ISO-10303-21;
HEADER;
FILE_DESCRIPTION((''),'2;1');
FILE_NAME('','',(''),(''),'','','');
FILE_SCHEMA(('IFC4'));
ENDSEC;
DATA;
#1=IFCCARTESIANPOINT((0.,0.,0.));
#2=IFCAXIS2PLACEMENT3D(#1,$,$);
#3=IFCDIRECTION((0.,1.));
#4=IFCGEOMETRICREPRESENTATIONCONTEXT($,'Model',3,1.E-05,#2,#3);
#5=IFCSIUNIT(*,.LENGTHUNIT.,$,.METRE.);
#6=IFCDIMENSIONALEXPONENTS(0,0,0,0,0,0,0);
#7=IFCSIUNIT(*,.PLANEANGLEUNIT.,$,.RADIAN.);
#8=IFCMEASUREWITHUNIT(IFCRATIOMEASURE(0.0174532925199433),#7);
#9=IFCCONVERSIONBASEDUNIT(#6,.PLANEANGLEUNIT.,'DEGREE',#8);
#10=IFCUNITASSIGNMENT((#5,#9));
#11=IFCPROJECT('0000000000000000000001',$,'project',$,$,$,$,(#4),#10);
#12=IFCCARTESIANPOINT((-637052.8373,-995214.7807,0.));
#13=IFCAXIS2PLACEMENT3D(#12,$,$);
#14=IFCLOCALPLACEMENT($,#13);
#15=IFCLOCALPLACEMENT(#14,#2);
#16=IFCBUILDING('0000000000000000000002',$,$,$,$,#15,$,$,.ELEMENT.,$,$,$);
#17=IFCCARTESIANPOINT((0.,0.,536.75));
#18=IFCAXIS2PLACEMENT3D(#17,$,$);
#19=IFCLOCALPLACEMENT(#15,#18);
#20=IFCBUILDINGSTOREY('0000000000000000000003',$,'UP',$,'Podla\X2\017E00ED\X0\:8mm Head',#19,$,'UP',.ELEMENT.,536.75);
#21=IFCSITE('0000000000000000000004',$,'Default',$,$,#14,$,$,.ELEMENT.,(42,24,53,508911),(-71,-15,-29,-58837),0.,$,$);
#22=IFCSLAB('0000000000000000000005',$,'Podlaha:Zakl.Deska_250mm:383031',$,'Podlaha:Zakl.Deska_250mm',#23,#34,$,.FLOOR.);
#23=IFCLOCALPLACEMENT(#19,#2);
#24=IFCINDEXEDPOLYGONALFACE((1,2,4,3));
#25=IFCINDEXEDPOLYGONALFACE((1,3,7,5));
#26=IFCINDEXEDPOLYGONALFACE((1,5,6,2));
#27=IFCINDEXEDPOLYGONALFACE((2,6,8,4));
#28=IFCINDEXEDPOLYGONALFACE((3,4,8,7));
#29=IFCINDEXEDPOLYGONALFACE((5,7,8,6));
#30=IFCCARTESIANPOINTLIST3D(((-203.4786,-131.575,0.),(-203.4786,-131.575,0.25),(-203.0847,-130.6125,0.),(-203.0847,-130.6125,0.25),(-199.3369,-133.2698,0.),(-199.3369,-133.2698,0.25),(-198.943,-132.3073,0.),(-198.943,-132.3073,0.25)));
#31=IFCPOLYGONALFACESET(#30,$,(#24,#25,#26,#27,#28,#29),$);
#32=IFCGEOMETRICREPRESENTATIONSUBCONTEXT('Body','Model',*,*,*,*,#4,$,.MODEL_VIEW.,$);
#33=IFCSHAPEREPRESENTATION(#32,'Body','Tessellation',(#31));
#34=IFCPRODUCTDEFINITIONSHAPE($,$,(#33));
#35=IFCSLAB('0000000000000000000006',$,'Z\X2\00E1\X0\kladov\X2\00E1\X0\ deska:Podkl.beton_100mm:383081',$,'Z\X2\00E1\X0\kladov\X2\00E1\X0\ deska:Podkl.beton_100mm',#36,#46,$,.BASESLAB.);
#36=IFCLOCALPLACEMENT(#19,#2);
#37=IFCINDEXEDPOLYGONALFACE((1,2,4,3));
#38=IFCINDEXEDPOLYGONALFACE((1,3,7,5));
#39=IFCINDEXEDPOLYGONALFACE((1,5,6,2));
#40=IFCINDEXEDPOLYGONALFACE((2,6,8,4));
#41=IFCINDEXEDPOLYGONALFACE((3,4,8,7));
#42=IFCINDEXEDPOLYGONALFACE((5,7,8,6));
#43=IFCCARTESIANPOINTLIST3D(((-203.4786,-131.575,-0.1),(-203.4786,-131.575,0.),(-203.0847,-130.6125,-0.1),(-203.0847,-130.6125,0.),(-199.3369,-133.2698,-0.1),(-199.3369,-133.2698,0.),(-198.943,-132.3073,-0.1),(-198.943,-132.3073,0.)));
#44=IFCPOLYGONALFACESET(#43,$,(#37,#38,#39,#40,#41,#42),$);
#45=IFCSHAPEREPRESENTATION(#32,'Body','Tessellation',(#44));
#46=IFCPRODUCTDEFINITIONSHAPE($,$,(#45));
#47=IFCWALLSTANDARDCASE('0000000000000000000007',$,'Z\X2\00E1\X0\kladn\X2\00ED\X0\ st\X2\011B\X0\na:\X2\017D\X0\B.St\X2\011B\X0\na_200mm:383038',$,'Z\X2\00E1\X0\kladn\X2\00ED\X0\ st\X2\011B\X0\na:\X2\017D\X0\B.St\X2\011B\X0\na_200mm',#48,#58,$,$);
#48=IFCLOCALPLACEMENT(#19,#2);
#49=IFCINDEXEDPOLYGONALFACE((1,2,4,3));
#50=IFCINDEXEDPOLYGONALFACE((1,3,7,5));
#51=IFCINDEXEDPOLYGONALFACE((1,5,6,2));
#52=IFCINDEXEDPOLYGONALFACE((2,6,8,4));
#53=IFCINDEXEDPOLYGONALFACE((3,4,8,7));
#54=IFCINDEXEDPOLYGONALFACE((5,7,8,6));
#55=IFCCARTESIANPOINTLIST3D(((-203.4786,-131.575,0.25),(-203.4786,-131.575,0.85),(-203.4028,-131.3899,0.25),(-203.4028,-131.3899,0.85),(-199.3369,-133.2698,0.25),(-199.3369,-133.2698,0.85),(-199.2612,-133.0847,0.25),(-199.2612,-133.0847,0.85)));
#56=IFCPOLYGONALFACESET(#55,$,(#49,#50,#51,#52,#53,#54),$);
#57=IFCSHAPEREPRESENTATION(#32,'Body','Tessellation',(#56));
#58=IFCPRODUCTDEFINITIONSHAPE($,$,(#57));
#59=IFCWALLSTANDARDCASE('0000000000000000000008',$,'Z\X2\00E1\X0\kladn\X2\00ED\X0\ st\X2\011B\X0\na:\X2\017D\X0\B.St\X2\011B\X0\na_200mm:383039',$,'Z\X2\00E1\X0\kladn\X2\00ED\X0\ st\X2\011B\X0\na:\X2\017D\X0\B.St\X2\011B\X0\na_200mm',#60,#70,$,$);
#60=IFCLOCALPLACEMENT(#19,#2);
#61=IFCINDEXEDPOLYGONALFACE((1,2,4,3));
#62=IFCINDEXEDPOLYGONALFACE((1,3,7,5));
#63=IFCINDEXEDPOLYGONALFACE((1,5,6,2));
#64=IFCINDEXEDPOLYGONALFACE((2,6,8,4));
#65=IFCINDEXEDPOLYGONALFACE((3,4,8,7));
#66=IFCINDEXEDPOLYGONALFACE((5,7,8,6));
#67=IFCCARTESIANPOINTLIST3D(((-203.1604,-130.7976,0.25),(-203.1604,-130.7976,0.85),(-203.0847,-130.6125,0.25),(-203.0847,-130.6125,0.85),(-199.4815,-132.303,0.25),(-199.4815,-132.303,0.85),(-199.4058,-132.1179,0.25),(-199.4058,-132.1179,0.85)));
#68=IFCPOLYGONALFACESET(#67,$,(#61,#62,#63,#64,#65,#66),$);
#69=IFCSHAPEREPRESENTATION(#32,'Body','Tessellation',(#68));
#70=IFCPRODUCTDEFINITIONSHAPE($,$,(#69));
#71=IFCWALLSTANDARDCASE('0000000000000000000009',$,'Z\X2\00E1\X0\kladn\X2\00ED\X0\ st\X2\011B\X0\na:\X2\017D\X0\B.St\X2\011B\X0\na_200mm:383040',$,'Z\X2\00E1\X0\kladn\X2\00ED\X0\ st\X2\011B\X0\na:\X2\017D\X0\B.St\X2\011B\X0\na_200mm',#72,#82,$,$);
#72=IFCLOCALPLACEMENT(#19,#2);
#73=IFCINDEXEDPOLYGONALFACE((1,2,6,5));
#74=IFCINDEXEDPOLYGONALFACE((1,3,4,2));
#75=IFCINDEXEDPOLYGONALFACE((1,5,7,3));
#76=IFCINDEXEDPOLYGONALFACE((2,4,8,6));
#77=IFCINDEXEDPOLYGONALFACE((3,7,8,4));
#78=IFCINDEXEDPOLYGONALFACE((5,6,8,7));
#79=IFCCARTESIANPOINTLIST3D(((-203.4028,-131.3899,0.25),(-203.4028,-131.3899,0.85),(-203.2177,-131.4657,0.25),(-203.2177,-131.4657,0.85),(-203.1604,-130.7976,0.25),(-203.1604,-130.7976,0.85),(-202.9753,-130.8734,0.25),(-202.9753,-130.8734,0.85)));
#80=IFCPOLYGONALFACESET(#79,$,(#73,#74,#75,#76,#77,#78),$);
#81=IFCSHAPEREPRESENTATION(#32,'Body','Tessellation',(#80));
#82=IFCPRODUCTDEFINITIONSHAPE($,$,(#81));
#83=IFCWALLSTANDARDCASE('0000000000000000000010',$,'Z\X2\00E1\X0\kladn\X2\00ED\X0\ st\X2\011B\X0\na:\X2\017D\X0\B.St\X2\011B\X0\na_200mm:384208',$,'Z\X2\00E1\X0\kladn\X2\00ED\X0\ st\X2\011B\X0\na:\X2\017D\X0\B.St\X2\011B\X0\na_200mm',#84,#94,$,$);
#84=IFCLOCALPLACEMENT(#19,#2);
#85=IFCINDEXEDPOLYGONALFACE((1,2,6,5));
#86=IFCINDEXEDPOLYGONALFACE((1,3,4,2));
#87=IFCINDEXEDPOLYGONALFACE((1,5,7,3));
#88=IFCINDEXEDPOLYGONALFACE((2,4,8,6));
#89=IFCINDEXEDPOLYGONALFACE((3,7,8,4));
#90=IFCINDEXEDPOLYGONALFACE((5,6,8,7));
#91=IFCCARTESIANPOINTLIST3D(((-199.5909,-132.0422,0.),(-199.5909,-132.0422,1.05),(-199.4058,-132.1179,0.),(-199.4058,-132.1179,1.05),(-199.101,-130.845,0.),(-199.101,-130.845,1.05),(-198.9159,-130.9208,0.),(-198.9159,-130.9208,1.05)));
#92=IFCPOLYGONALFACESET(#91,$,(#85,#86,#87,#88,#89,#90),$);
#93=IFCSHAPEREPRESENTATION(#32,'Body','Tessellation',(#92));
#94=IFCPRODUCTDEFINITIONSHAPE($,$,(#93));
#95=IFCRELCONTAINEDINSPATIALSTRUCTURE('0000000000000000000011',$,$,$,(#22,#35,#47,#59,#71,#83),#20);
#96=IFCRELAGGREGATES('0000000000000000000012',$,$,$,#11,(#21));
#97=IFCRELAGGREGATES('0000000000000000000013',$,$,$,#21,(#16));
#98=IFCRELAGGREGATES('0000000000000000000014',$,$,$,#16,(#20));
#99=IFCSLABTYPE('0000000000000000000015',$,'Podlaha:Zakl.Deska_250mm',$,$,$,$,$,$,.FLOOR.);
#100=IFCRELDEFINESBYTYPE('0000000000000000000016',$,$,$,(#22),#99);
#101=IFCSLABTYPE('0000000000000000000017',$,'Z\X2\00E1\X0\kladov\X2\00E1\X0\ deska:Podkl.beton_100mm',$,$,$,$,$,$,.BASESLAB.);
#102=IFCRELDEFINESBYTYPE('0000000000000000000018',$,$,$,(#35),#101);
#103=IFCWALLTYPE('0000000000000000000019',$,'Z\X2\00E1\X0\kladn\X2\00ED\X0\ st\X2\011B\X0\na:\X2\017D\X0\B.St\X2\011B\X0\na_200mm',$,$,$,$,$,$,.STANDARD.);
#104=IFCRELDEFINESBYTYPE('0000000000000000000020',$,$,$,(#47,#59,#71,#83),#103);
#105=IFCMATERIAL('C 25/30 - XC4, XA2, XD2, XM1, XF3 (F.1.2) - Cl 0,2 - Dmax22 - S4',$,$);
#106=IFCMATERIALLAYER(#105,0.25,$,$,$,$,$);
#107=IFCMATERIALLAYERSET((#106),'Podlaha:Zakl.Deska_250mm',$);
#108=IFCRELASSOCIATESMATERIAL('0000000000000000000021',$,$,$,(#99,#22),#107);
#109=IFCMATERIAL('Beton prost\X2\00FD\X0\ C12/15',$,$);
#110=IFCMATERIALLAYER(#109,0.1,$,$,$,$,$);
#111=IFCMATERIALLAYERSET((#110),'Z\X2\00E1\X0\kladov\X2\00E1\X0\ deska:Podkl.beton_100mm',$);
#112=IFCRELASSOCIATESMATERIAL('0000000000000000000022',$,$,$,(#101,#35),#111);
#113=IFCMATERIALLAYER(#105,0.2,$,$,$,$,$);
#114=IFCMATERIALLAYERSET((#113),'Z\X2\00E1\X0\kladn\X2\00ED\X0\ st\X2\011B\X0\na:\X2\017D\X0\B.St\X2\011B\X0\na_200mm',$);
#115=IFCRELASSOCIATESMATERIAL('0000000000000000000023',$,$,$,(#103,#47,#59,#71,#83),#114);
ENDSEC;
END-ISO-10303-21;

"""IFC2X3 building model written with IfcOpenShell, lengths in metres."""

from ifc_helpers import new_model, entity, si_unit, converted_unit, direction, frame, frame_2d, origin, place, context, subcontext, project, spatial, polyline, rectangle, extrude, clip, bounded_halfspace, material, layer, layer_set, layer_usage, type_object, element, save


model = new_model("IFC2X3")

# Units and contexts
model_context = context("Model", 3, precision=1e-05, world=origin(), true_north=direction((0.0, 1.0)))
body_context = subcontext(model_context, "Body", "Model", "MODEL_VIEW")
ifc_project = project(units=[si_unit("LENGTHUNIT", "METRE"), converted_unit("PLANEANGLEUNIT", "DEGREE", entity("IfcRatioMeasure", 0.0174532925199433), si_unit("PLANEANGLEUNIT", "RADIAN"), dimensions=[0, 0, 0, 0, 0, 0, 0])], contexts=[model_context])

# Site, building, storey
site_placement = place(None, frame((-637052.8373, -995214.7807, 0.0)))
site = spatial("IfcSite", under=ifc_project, at=site_placement, Name="Default", CompositionType="ELEMENT", RefLatitude=(42, 24, 53, 508911), RefLongitude=(-71, -15, -29, -58837), RefElevation=0.0)
building_placement = place(site_placement, origin())
building = spatial("IfcBuilding", under=site, at=building_placement, CompositionType="ELEMENT")
storey_placement = place(building_placement, frame((0.0, 0.0, 536.75)))
storey = spatial("IfcBuildingStorey", under=building, at=storey_placement, Name="UP", ObjectType="Podlaží:8mm Head", LongName="UP", CompositionType="ELEMENT", Elevation=536.75)

# Slabs
ifc_material_1 = material(Name="C 25/30 - XC4, XA2, XD2, XM1, XF3 (F.1.2) - Cl 0,2 - Dmax22 - S4")
ifc_layer_1 = layer(ifc_material_1, 0.25)
ifc_layer_set_1 = layer_set([ifc_layer_1], Name="Podlaha:Zakl.Deska_250mm")
ifc_layer_usage_1 = layer_usage(ifc_layer_set_1, "AXIS3", "POSITIVE", 0.0)
slab_type_1 = type_object("IfcSlabType", Name="Podlaha:Zakl.Deska_250mm", PredefinedType="FLOOR", material=ifc_layer_set_1)
slab_1_placement = place(storey_placement, origin())
element("IfcSlab", 1, at=slab_1_placement, inside=storey, type_object=slab_type_1, material=ifc_layer_usage_1, Name="Podlaha:Zakl.Deska_250mm:383031", ObjectType="Podlaha:Zakl.Deska_250mm", PredefinedType="FLOOR", context=body_context, shape_type="SweptSolid", body=[
    extrude(rectangle(XDim=1.04, YDim=4.475, at=frame_2d((0.0, 0.0), x_axis=(1.0, 0.0))), frame((-201.2108, -131.9412, 0.25), z_axis=(0.0, 0.0, -1.0), x_axis=(-0.378722, -0.92551, 0.0)), (0.0, 0.0, 1.0), 0.25),
])
ifc_material_2 = material(Name="Beton prostý C12/15")
ifc_layer_2 = layer(ifc_material_2, 0.1)
ifc_layer_set_2 = layer_set([ifc_layer_2], Name="Základová deska:Podkl.beton_100mm")
ifc_layer_usage_2 = layer_usage(ifc_layer_set_2, "AXIS3", "POSITIVE", 0.0)
slab_type_2 = type_object("IfcSlabType", Name="Základová deska:Podkl.beton_100mm", PredefinedType="BASESLAB", material=ifc_layer_set_2)
slab_2_placement = place(storey_placement, origin())
element("IfcSlab", 2, at=slab_2_placement, inside=storey, type_object=slab_type_2, material=ifc_layer_usage_2, Name="Základová deska:Podkl.beton_100mm:383081", ObjectType="Základová deska:Podkl.beton_100mm", PredefinedType="BASESLAB", context=body_context, shape_type="SweptSolid", body=[
    extrude(rectangle(XDim=4.475, YDim=1.04, at=frame_2d((0.0, 0.0), x_axis=(1.0, 0.0))), frame((-201.2108, -131.9412, 0.0), z_axis=(0.0, 0.0, -1.0), x_axis=(0.92551, -0.378722, 0.0)), (0.0, 0.0, 1.0), 0.1),
])

# Walls
ifc_layer_3 = layer(ifc_material_1, 0.2)
ifc_layer_set_3 = layer_set([ifc_layer_3], Name="Základní stěna:ŽB.Stěna_200mm")
ifc_layer_usage_3 = layer_usage(ifc_layer_set_3, "AXIS2", "NEGATIVE", 0.1)
wall_type = type_object("IfcWallType", Name="Základní stěna:ŽB.Stěna_200mm", PredefinedType="STANDARD", material=ifc_layer_set_3)
wall_1_placement = place(storey_placement, frame((-199.299, -133.1773, 0.25), z_axis=(0.0, 0.0, 1.0), x_axis=(-0.92551, 0.378722, 0.0)))
element("IfcWallStandardCase", 3, at=wall_1_placement, inside=storey, type_object=wall_type, material=ifc_layer_usage_3, Name="Základní stěna:ŽB.Stěna_200mm:383038", ObjectType="Základní stěna:ŽB.Stěna_200mm", context=body_context, shape_type="Clipping", body=[
    clip(extrude(rectangle(XDim=4.475, YDim=0.2, at=frame_2d((2.2375, 0.0), x_axis=(-1.0, 0.0))), origin(), (0.0, 0.0, 1.0), 0.6), bounded_halfspace(frame((0.0, -0.1, 0.6), z_axis=(0.0, 0.0, -1.0), x_axis=(-1.0, 0.0, 0.0)), True, frame((0.0, -0.1, 0.6)), polyline([(0.0, 0.0), (4.275, 0.0), (4.475, 0.0), (4.475, 0.2), (0.0, 0.2), (0.0, 0.0)]))),
])
ifc_layer_usage_4 = layer_usage(ifc_layer_set_3, "AXIS2", "NEGATIVE", 0.1)
wall_2_placement = place(storey_placement, frame((-203.1226, -130.7051, 0.25), z_axis=(0.0, 0.0, 1.0), x_axis=(0.92551, -0.378722, 0.0)))
element("IfcWallStandardCase", 4, at=wall_2_placement, inside=storey, type_object=wall_type, material=ifc_layer_usage_4, Name="Základní stěna:ŽB.Stěna_200mm:383039", ObjectType="Základní stěna:ŽB.Stěna_200mm", context=body_context, shape_type="Clipping", body=[
    clip(extrude(rectangle(XDim=3.975, YDim=0.2, at=frame_2d((1.9875, 0.0), x_axis=(-1.0, 0.0))), origin(), (0.0, 0.0, 1.0), 0.6), bounded_halfspace(frame((0.0, -0.1, 0.6), z_axis=(0.0, 0.0, -1.0), x_axis=(1.0, 0.0, 0.0)), True, frame((0.0, -0.1, 0.6)), polyline([(0.0, 0.0), (0.2, 0.0), (3.975, 0.0), (3.975, 0.2), (0.0, 0.2), (0.0, 0.0)]))),
])
ifc_layer_usage_5 = layer_usage(ifc_layer_set_3, "AXIS2", "NEGATIVE", 0.1)
wall_3_placement = place(storey_placement, frame((-203.3103, -131.4278, 0.25), z_axis=(0.0, 0.0, 1.0), x_axis=(0.378722, 0.92551, 0.0)))
element("IfcWallStandardCase", 5, at=wall_3_placement, inside=storey, type_object=wall_type, material=ifc_layer_usage_5, Name="Základní stěna:ŽB.Stěna_200mm:383040", ObjectType="Základní stěna:ŽB.Stěna_200mm", context=body_context, shape_type="Clipping", body=[
    clip(extrude(rectangle(XDim=0.64, YDim=0.2, at=frame_2d((0.32, 0.0), x_axis=(-1.0, 0.0))), origin(), (0.0, 0.0, 1.0), 0.6), bounded_halfspace(frame((0.0, -0.1, 0.6), z_axis=(0.0, 0.0, -1.0), x_axis=(0.0, -1.0, 0.0)), True, frame((0.0, -0.1, 0.6)), polyline([(0.0, 0.0), (0.64, 0.0), (0.64, 0.2), (0.0, 0.2), (0.0, 0.0)]))),
])
ifc_layer_usage_6 = layer_usage(ifc_layer_set_3, "AXIS2", "NEGATIVE", 0.1)
wall_4_placement = place(storey_placement, frame((-199.4983, -132.0801, 0.0), z_axis=(0.0, 0.0, 1.0), x_axis=(0.378722, 0.92551, 0.0)))
element("IfcWallStandardCase", 6, at=wall_4_placement, inside=storey, type_object=wall_type, material=ifc_layer_usage_6, Name="Základní stěna:ŽB.Stěna_200mm:384208", ObjectType="Základní stěna:ŽB.Stěna_200mm", context=body_context, shape_type="SweptSolid", body=[
    extrude(rectangle(XDim=1.2935, YDim=0.2, at=frame_2d((0.6467, 0.0), x_axis=(-1.0, 0.0))), origin(), (0.0, 0.0, 1.0), 1.05),
])

save(model, "model.ifc")
